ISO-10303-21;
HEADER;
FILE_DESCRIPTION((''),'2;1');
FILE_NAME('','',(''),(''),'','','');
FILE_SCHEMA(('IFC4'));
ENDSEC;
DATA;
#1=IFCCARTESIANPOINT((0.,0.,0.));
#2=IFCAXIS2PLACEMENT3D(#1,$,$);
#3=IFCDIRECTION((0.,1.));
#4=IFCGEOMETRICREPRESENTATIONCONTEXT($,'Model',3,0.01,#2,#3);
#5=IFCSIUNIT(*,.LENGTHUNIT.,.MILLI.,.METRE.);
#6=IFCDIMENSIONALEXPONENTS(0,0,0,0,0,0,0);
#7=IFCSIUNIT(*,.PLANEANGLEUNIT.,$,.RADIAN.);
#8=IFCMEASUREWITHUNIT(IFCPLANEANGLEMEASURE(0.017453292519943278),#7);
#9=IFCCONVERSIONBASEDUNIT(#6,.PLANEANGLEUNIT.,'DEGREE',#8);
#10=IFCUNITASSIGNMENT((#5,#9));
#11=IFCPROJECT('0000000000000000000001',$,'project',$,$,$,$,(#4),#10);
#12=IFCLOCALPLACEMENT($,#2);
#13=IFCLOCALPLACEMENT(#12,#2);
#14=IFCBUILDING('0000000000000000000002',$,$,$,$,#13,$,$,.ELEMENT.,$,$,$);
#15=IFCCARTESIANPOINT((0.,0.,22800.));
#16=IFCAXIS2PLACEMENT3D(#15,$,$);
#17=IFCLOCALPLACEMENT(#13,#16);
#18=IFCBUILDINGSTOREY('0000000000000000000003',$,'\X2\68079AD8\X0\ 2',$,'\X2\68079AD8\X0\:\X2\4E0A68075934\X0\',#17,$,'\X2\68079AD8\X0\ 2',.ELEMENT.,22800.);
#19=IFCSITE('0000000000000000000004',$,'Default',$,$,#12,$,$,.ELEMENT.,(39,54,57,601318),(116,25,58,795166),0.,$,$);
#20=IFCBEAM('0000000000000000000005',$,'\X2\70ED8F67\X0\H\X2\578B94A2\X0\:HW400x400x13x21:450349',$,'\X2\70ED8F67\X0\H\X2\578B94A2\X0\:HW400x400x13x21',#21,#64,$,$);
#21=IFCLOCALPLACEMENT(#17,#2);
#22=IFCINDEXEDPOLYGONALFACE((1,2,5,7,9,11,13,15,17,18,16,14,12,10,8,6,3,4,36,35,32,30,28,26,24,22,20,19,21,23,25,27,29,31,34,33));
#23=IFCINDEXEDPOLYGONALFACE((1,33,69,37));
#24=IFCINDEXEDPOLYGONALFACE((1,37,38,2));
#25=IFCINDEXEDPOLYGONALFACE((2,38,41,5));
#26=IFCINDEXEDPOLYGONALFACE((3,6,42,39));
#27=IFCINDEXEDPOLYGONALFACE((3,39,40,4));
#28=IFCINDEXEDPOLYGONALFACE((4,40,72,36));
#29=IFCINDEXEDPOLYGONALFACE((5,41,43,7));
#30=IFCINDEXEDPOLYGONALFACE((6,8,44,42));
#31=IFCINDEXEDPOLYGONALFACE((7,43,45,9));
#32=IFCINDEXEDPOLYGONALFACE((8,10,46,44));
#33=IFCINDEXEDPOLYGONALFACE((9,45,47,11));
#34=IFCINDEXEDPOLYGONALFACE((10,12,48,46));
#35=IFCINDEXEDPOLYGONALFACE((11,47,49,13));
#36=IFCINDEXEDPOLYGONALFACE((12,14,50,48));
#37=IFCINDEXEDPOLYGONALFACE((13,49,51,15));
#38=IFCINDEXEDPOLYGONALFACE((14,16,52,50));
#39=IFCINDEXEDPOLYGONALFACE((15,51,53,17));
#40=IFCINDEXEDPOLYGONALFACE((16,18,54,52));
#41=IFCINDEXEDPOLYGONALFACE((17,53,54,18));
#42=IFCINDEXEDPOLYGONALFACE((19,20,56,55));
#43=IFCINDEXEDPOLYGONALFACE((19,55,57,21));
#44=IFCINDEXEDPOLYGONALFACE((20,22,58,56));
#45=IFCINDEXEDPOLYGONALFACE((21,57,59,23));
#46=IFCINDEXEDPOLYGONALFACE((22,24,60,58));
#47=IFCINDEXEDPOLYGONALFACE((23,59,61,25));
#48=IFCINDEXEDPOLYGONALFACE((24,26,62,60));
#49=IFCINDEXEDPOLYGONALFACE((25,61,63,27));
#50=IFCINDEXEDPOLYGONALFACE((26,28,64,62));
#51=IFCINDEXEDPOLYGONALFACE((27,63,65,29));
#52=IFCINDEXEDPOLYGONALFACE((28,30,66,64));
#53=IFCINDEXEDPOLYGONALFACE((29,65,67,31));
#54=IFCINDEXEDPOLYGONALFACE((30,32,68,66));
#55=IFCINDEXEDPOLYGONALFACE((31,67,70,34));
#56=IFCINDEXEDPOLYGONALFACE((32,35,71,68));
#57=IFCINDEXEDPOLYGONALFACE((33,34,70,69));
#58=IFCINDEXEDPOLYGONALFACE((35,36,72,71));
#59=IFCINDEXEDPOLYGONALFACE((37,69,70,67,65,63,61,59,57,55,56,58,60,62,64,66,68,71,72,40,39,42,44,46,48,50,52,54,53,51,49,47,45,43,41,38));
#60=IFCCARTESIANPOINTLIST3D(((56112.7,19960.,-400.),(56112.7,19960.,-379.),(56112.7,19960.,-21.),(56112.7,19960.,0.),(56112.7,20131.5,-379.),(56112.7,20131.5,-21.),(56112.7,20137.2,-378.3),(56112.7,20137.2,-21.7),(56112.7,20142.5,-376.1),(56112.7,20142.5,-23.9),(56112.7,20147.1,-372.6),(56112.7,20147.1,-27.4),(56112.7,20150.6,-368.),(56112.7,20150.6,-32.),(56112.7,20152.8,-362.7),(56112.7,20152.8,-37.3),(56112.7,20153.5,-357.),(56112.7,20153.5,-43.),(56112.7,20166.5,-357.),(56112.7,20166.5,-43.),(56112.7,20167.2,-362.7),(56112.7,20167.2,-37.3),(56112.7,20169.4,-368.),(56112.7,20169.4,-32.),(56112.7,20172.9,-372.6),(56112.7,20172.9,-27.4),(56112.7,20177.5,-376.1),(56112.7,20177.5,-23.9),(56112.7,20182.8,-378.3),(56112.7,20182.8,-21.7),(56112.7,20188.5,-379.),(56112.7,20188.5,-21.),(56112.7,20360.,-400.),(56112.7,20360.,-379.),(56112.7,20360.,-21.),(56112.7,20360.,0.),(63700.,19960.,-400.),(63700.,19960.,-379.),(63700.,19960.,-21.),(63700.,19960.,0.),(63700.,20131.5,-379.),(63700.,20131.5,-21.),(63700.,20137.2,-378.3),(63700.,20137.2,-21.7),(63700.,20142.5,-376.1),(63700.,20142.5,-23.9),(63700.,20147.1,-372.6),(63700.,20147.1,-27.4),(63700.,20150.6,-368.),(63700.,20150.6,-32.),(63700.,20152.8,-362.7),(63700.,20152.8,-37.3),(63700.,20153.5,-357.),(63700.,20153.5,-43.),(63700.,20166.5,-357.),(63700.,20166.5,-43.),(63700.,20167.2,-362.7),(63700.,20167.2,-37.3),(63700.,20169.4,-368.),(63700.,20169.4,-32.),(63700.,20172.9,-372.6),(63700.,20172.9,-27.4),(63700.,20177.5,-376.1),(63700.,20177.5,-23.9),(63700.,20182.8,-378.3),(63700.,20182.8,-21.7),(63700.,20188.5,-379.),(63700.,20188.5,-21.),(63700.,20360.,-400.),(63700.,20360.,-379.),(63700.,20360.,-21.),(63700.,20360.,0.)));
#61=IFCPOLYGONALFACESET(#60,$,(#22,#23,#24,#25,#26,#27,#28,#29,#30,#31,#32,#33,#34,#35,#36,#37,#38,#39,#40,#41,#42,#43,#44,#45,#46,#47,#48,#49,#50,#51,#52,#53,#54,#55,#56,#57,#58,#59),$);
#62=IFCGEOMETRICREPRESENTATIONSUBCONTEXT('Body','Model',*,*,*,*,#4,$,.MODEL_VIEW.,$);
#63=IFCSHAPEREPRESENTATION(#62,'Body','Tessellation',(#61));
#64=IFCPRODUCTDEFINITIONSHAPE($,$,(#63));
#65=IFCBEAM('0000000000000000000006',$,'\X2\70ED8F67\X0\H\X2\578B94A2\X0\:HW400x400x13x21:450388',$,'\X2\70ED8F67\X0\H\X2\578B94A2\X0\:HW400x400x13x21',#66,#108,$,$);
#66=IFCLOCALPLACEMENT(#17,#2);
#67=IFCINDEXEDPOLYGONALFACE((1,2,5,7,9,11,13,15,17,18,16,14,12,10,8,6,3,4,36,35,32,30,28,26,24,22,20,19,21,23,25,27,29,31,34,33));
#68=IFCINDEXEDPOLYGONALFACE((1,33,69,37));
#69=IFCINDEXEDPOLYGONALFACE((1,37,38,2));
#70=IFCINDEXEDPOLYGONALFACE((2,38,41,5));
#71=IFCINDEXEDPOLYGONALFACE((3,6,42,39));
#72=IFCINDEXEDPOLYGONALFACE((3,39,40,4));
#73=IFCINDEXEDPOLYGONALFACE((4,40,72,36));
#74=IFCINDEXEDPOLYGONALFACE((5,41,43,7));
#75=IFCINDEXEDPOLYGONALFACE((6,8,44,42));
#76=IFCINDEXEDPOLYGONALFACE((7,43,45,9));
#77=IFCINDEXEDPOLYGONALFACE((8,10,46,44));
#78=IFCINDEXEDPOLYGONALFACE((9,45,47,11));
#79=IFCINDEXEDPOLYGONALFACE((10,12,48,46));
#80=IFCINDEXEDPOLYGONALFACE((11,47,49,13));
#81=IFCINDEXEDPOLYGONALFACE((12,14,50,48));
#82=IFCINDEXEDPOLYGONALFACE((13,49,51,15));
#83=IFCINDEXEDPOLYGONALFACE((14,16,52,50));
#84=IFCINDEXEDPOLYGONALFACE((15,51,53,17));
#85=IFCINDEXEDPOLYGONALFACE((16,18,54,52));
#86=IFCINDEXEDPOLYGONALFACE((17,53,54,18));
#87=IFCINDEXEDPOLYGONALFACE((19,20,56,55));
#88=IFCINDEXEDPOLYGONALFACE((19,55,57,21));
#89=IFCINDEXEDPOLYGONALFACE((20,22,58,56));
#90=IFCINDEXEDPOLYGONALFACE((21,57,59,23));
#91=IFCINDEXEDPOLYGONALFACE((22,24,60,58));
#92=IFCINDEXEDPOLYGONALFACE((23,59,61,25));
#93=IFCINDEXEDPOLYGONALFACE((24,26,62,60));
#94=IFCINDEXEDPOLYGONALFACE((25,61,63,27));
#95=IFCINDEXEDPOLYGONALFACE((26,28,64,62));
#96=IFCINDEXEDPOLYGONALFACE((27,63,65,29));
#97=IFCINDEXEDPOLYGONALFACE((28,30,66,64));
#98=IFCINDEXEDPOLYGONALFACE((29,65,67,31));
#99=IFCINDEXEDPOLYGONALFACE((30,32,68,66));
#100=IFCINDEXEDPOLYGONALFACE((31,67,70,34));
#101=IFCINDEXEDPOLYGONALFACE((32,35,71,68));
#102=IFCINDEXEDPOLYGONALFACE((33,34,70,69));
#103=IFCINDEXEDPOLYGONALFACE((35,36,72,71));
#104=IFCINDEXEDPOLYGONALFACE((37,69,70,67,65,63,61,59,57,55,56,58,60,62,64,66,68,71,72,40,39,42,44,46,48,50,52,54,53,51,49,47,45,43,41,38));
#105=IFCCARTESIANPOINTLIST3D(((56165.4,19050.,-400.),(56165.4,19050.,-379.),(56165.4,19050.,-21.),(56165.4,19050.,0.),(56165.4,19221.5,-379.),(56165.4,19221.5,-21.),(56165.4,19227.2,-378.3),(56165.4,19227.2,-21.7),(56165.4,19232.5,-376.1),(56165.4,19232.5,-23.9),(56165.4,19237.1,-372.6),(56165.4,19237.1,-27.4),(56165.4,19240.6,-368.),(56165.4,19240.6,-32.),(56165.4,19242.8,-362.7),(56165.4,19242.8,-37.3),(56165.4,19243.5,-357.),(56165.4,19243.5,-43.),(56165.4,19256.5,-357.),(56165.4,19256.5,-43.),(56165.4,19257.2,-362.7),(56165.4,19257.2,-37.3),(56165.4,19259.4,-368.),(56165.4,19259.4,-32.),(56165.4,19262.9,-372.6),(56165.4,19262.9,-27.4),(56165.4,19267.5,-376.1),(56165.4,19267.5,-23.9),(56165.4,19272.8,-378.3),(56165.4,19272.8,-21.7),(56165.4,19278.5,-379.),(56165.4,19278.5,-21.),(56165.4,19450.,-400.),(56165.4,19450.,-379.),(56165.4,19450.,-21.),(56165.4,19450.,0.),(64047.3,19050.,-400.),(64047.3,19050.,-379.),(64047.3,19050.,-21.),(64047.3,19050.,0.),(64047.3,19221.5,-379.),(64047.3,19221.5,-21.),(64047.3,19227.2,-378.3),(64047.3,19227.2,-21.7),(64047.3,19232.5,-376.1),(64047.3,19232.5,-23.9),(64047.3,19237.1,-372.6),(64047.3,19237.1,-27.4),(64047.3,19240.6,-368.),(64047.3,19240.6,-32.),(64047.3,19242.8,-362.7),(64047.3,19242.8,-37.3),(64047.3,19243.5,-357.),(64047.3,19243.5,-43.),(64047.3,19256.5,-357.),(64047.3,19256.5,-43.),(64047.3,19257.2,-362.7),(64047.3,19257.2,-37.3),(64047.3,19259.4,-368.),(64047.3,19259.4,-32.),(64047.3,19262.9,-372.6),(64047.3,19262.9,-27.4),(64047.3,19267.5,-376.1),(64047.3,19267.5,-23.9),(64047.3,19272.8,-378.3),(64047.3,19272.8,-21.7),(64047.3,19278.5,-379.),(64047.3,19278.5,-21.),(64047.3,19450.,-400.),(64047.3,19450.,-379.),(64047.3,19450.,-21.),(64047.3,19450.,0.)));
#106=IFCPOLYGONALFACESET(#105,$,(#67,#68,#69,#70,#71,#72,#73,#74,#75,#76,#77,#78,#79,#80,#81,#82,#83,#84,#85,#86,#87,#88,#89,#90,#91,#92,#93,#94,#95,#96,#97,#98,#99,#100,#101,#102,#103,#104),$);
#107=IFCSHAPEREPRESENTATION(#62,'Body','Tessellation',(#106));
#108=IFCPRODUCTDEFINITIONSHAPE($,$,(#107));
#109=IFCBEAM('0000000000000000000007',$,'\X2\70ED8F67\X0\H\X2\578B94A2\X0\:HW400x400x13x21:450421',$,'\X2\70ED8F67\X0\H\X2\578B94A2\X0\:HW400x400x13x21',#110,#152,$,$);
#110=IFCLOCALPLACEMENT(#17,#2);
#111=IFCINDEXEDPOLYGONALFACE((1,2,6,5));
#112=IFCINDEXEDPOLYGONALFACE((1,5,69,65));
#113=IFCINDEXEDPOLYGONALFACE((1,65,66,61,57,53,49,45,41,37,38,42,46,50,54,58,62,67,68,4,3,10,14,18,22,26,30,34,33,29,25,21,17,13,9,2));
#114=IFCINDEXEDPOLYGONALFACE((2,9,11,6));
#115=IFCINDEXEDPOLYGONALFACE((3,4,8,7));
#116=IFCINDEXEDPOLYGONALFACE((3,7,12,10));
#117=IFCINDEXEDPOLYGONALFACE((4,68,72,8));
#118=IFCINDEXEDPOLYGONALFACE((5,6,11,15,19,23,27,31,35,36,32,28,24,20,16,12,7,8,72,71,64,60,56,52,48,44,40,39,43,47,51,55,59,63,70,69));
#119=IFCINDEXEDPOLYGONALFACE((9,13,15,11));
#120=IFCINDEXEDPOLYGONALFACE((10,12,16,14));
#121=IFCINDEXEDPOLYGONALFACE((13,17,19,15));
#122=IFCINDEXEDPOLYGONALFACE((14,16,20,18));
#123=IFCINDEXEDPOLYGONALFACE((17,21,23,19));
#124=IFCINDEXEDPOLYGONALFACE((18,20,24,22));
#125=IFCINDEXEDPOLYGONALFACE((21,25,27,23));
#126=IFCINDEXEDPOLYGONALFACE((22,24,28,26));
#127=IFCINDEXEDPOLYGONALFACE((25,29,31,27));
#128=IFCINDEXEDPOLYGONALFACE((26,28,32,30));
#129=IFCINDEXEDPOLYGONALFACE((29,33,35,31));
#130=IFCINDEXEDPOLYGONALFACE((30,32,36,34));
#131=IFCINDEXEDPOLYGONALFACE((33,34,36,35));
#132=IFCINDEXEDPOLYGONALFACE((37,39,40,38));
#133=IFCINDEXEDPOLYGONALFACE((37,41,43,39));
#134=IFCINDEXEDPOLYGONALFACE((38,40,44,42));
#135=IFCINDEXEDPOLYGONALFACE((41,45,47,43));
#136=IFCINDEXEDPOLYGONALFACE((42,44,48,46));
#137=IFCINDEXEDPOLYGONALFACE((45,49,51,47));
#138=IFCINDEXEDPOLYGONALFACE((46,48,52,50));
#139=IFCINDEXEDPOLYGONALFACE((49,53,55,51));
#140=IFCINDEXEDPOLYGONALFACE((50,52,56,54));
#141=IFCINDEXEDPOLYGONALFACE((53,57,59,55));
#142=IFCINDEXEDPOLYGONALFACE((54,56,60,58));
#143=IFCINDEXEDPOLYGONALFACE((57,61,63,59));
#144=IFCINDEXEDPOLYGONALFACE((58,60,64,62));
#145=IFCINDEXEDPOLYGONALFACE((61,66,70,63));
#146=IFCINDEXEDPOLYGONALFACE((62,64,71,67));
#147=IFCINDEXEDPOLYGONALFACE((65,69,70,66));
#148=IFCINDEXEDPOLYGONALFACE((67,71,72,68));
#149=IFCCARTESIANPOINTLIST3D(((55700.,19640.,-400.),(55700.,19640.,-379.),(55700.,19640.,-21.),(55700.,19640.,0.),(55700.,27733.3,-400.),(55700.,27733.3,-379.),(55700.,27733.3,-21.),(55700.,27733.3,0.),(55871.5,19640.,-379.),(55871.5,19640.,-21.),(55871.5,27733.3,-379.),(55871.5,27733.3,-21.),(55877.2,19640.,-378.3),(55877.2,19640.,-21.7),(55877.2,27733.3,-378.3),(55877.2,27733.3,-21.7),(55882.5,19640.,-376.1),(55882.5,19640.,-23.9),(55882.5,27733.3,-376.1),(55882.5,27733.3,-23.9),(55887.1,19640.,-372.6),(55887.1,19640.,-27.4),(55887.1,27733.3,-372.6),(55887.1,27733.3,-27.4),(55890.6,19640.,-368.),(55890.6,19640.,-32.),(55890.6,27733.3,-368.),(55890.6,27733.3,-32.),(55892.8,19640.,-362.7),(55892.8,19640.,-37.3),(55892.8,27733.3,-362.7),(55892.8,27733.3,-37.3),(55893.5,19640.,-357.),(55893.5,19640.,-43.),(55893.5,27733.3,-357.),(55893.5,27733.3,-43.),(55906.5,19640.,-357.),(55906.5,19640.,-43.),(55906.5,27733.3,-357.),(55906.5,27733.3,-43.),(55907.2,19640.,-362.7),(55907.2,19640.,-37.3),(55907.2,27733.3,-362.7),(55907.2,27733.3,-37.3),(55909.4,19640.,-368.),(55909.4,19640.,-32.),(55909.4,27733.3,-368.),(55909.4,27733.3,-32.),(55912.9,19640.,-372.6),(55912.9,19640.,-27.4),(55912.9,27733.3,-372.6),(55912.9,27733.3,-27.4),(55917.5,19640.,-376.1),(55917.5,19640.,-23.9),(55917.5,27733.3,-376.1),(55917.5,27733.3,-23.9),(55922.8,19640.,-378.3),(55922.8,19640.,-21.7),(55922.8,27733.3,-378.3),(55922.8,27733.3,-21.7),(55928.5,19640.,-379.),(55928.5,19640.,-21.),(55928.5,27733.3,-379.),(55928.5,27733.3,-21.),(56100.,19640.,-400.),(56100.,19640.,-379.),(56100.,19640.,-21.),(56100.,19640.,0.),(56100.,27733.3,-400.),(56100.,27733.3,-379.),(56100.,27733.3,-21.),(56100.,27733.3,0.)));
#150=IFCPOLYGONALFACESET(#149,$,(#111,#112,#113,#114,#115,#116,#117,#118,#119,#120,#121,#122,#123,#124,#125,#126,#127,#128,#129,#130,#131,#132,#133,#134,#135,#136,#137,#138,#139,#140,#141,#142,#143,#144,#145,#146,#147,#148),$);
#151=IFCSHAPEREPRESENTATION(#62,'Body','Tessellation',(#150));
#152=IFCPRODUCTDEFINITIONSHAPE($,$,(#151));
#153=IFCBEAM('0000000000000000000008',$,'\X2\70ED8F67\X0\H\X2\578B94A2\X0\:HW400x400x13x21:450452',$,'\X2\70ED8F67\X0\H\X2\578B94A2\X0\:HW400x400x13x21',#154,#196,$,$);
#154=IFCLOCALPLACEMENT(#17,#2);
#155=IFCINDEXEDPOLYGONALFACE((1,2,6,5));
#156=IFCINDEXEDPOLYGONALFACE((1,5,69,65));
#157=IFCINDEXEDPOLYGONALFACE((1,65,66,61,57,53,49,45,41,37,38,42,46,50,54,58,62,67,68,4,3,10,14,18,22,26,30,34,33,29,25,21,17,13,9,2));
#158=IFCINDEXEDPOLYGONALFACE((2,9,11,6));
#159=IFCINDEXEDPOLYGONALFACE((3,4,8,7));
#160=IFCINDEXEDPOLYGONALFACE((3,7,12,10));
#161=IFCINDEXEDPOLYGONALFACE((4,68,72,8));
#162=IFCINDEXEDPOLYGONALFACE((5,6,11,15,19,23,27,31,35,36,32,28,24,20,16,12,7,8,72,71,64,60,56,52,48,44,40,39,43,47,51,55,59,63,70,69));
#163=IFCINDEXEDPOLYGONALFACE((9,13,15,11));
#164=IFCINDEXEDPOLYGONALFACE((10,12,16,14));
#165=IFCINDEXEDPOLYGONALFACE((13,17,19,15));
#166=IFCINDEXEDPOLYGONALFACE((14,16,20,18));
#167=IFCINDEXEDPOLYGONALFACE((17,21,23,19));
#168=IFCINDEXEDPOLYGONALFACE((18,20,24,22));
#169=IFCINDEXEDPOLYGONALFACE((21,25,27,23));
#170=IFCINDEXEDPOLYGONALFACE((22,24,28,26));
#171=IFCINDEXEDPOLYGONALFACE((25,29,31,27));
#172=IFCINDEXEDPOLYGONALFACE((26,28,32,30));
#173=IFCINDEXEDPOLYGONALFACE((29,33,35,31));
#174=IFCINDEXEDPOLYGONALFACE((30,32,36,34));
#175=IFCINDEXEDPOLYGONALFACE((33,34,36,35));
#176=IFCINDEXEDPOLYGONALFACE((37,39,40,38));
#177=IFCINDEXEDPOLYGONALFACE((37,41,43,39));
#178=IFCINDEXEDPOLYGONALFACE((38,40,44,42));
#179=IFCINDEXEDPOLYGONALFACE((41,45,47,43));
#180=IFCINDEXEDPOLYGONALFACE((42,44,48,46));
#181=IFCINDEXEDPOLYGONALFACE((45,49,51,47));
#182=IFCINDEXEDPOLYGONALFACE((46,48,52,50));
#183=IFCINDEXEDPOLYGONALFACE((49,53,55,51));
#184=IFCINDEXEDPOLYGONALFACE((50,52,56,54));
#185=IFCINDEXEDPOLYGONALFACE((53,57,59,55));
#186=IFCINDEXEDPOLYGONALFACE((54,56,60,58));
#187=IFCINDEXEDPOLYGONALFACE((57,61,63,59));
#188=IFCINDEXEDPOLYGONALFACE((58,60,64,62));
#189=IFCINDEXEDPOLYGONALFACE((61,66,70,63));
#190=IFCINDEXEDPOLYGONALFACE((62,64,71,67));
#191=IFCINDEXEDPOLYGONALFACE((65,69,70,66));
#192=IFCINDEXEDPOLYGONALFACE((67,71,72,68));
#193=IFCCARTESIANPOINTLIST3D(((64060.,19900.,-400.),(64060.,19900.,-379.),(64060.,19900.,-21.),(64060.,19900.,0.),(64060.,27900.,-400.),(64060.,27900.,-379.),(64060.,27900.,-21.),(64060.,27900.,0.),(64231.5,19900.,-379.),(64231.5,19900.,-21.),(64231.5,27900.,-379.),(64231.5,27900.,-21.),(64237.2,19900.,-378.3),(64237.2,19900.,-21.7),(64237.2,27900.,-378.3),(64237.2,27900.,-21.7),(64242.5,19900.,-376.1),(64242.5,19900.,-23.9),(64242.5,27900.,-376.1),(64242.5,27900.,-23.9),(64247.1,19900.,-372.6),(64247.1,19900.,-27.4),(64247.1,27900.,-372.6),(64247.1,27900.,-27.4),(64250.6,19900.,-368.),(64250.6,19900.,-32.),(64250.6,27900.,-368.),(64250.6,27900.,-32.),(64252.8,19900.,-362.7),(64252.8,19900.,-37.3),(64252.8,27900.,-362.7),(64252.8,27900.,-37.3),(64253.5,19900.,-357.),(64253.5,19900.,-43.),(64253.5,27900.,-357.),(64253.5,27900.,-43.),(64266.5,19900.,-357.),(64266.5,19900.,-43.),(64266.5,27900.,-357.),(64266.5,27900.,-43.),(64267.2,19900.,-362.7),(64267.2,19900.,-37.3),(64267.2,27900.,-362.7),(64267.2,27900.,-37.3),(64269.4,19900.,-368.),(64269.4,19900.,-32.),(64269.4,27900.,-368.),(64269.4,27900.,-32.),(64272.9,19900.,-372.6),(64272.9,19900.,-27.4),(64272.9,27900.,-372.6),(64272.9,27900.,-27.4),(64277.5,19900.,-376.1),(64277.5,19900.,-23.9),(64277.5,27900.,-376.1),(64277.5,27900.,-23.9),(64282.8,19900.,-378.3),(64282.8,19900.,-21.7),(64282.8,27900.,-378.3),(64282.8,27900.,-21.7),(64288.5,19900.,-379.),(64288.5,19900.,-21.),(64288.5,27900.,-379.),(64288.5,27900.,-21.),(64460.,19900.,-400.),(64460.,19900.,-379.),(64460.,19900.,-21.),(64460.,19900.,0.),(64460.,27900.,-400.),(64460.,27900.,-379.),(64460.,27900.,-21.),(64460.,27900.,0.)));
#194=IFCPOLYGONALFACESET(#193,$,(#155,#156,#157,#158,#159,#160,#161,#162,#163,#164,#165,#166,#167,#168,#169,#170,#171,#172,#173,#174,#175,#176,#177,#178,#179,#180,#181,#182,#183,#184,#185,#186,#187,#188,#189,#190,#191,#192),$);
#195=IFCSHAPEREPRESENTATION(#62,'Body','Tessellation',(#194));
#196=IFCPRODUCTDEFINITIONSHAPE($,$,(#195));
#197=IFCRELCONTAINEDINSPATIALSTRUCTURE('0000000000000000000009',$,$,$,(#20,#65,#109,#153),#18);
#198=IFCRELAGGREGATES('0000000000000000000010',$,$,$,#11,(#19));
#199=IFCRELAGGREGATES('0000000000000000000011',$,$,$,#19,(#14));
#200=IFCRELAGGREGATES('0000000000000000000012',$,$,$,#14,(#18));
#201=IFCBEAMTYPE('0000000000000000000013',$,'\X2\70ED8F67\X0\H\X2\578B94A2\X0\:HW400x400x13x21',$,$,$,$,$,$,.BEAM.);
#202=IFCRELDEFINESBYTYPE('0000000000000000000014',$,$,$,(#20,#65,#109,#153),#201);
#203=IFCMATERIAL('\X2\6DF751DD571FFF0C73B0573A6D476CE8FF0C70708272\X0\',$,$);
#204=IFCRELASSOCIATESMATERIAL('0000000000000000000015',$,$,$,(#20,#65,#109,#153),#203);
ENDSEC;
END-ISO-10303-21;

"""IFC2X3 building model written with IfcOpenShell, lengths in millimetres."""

from ifc_helpers import new_model, entity, si_unit, converted_unit, direction, frame, frame_2d, origin, place, context, subcontext, project, spatial, i_section, extrude, material, type_object, element, save


model = new_model("IFC2X3")

# Units and contexts
model_context = context("Model", 3, precision=0.01, world=origin(), true_north=direction((0.0, 1.0)))
body_context = subcontext(model_context, "Body", "Model", "MODEL_VIEW")
ifc_project = project(units=[si_unit("LENGTHUNIT", "METRE", prefix="MILLI"), converted_unit("PLANEANGLEUNIT", "DEGREE", entity("IfcPlaneAngleMeasure", 0.017453292519943278), si_unit("PLANEANGLEUNIT", "RADIAN"), dimensions=[0, 0, 0, 0, 0, 0, 0])], contexts=[model_context])

# Site, building, storey
site_placement = place(None, origin())
site = spatial("IfcSite", under=ifc_project, at=site_placement, Name="Default", CompositionType="ELEMENT", RefLatitude=(39, 54, 57, 601318), RefLongitude=(116, 25, 58, 795166), RefElevation=0.0)
building_placement = place(site_placement, origin())
building = spatial("IfcBuilding", under=site, at=building_placement, CompositionType="ELEMENT")
storey_placement = place(building_placement, frame((0.0, 0.0, 22800.0)))
storey = spatial("IfcBuildingStorey", under=building, at=storey_placement, Name="标高 2", ObjectType="标高:上标头", LongName="标高 2", CompositionType="ELEMENT", Elevation=22800.0)

# Beams
ifc_material = material(Name="混凝土，现场浇注，灰色")
beam_type = type_object("IfcBeamType", Name="热轧H型钢:HW400x400x13x21", PredefinedType="BEAM")
beam_1_placement = place(storey_placement, frame((55900.0, 20160.0, 0.0)))
element("IfcBeam", 1, at=beam_1_placement, inside=storey, type_object=beam_type, material=ifc_material, Name="热轧H型钢:HW400x400x13x21:450349", ObjectType="热轧H型钢:HW400x400x13x21", context=body_context, shape_type="SweptSolid", body=[
    extrude(i_section(OverallWidth=400.0, OverallDepth=400.0, WebThickness=13.0, FlangeThickness=21.0, FilletRadius=22.0, at=frame_2d((0.0, 0.0), x_axis=(0.0, 1.0))), frame((212.7, 0.0, -200.0), z_axis=(1.0, 0.0, 0.0), x_axis=(0.0, 0.0, -1.0)), (0.0, 0.0, 1.0), 7587.3),
])
beam_2_placement = place(storey_placement, frame((64260.0, 19250.0, 0.0), z_axis=(0.0, 0.0, 1.0), x_axis=(-1.0, 0.0, 0.0)))
element("IfcBeam", 2, at=beam_2_placement, inside=storey, type_object=beam_type, material=ifc_material, Name="热轧H型钢:HW400x400x13x21:450388", ObjectType="热轧H型钢:HW400x400x13x21", context=body_context, shape_type="SweptSolid", body=[
    extrude(i_section(OverallWidth=400.0, OverallDepth=400.0, WebThickness=13.0, FlangeThickness=21.0, FilletRadius=22.0, at=frame_2d((0.0, 0.0), x_axis=(0.0, 1.0))), frame((212.7, 0.0, -200.0), z_axis=(1.0, 0.0, 0.0), x_axis=(0.0, 0.0, -1.0)), (0.0, 0.0, 1.0), 7881.9),
])
beam_3_placement = place(storey_placement, frame((55900.0, 27800.0, 0.0), z_axis=(0.0, 0.0, 1.0), x_axis=(0.0, -1.0, 0.0)))
element("IfcBeam", 3, at=beam_3_placement, inside=storey, type_object=beam_type, material=ifc_material, Name="热轧H型钢:HW400x400x13x21:450421", ObjectType="热轧H型钢:HW400x400x13x21", context=body_context, shape_type="SweptSolid", body=[
    extrude(i_section(OverallWidth=400.0, OverallDepth=400.0, WebThickness=13.0, FlangeThickness=21.0, FilletRadius=22.0, at=frame_2d((0.0, 0.0), x_axis=(0.0, 1.0))), frame((66.7, 0.0, -200.0), z_axis=(1.0, 0.0, 0.0), x_axis=(0.0, 0.0, -1.0)), (0.0, 0.0, 1.0), 8093.3),
])
beam_4_placement = place(storey_placement, frame((64260.0, 27900.0, 0.0), z_axis=(0.0, 0.0, 1.0), x_axis=(0.0, -1.0, 0.0)))
element("IfcBeam", 4, at=beam_4_placement, inside=storey, type_object=beam_type, material=ifc_material, Name="热轧H型钢:HW400x400x13x21:450452", ObjectType="热轧H型钢:HW400x400x13x21", context=body_context, shape_type="SweptSolid", body=[
    extrude(i_section(OverallWidth=400.0, OverallDepth=400.0, WebThickness=13.0, FlangeThickness=21.0, FilletRadius=22.0, at=frame_2d((0.0, 0.0), x_axis=(0.0, 1.0))), frame((0.0, 0.0, -200.0), z_axis=(1.0, 0.0, 0.0), x_axis=(0.0, 0.0, -1.0)), (0.0, 0.0, 1.0), 8000.0),
])

save(model, "model.ifc")
